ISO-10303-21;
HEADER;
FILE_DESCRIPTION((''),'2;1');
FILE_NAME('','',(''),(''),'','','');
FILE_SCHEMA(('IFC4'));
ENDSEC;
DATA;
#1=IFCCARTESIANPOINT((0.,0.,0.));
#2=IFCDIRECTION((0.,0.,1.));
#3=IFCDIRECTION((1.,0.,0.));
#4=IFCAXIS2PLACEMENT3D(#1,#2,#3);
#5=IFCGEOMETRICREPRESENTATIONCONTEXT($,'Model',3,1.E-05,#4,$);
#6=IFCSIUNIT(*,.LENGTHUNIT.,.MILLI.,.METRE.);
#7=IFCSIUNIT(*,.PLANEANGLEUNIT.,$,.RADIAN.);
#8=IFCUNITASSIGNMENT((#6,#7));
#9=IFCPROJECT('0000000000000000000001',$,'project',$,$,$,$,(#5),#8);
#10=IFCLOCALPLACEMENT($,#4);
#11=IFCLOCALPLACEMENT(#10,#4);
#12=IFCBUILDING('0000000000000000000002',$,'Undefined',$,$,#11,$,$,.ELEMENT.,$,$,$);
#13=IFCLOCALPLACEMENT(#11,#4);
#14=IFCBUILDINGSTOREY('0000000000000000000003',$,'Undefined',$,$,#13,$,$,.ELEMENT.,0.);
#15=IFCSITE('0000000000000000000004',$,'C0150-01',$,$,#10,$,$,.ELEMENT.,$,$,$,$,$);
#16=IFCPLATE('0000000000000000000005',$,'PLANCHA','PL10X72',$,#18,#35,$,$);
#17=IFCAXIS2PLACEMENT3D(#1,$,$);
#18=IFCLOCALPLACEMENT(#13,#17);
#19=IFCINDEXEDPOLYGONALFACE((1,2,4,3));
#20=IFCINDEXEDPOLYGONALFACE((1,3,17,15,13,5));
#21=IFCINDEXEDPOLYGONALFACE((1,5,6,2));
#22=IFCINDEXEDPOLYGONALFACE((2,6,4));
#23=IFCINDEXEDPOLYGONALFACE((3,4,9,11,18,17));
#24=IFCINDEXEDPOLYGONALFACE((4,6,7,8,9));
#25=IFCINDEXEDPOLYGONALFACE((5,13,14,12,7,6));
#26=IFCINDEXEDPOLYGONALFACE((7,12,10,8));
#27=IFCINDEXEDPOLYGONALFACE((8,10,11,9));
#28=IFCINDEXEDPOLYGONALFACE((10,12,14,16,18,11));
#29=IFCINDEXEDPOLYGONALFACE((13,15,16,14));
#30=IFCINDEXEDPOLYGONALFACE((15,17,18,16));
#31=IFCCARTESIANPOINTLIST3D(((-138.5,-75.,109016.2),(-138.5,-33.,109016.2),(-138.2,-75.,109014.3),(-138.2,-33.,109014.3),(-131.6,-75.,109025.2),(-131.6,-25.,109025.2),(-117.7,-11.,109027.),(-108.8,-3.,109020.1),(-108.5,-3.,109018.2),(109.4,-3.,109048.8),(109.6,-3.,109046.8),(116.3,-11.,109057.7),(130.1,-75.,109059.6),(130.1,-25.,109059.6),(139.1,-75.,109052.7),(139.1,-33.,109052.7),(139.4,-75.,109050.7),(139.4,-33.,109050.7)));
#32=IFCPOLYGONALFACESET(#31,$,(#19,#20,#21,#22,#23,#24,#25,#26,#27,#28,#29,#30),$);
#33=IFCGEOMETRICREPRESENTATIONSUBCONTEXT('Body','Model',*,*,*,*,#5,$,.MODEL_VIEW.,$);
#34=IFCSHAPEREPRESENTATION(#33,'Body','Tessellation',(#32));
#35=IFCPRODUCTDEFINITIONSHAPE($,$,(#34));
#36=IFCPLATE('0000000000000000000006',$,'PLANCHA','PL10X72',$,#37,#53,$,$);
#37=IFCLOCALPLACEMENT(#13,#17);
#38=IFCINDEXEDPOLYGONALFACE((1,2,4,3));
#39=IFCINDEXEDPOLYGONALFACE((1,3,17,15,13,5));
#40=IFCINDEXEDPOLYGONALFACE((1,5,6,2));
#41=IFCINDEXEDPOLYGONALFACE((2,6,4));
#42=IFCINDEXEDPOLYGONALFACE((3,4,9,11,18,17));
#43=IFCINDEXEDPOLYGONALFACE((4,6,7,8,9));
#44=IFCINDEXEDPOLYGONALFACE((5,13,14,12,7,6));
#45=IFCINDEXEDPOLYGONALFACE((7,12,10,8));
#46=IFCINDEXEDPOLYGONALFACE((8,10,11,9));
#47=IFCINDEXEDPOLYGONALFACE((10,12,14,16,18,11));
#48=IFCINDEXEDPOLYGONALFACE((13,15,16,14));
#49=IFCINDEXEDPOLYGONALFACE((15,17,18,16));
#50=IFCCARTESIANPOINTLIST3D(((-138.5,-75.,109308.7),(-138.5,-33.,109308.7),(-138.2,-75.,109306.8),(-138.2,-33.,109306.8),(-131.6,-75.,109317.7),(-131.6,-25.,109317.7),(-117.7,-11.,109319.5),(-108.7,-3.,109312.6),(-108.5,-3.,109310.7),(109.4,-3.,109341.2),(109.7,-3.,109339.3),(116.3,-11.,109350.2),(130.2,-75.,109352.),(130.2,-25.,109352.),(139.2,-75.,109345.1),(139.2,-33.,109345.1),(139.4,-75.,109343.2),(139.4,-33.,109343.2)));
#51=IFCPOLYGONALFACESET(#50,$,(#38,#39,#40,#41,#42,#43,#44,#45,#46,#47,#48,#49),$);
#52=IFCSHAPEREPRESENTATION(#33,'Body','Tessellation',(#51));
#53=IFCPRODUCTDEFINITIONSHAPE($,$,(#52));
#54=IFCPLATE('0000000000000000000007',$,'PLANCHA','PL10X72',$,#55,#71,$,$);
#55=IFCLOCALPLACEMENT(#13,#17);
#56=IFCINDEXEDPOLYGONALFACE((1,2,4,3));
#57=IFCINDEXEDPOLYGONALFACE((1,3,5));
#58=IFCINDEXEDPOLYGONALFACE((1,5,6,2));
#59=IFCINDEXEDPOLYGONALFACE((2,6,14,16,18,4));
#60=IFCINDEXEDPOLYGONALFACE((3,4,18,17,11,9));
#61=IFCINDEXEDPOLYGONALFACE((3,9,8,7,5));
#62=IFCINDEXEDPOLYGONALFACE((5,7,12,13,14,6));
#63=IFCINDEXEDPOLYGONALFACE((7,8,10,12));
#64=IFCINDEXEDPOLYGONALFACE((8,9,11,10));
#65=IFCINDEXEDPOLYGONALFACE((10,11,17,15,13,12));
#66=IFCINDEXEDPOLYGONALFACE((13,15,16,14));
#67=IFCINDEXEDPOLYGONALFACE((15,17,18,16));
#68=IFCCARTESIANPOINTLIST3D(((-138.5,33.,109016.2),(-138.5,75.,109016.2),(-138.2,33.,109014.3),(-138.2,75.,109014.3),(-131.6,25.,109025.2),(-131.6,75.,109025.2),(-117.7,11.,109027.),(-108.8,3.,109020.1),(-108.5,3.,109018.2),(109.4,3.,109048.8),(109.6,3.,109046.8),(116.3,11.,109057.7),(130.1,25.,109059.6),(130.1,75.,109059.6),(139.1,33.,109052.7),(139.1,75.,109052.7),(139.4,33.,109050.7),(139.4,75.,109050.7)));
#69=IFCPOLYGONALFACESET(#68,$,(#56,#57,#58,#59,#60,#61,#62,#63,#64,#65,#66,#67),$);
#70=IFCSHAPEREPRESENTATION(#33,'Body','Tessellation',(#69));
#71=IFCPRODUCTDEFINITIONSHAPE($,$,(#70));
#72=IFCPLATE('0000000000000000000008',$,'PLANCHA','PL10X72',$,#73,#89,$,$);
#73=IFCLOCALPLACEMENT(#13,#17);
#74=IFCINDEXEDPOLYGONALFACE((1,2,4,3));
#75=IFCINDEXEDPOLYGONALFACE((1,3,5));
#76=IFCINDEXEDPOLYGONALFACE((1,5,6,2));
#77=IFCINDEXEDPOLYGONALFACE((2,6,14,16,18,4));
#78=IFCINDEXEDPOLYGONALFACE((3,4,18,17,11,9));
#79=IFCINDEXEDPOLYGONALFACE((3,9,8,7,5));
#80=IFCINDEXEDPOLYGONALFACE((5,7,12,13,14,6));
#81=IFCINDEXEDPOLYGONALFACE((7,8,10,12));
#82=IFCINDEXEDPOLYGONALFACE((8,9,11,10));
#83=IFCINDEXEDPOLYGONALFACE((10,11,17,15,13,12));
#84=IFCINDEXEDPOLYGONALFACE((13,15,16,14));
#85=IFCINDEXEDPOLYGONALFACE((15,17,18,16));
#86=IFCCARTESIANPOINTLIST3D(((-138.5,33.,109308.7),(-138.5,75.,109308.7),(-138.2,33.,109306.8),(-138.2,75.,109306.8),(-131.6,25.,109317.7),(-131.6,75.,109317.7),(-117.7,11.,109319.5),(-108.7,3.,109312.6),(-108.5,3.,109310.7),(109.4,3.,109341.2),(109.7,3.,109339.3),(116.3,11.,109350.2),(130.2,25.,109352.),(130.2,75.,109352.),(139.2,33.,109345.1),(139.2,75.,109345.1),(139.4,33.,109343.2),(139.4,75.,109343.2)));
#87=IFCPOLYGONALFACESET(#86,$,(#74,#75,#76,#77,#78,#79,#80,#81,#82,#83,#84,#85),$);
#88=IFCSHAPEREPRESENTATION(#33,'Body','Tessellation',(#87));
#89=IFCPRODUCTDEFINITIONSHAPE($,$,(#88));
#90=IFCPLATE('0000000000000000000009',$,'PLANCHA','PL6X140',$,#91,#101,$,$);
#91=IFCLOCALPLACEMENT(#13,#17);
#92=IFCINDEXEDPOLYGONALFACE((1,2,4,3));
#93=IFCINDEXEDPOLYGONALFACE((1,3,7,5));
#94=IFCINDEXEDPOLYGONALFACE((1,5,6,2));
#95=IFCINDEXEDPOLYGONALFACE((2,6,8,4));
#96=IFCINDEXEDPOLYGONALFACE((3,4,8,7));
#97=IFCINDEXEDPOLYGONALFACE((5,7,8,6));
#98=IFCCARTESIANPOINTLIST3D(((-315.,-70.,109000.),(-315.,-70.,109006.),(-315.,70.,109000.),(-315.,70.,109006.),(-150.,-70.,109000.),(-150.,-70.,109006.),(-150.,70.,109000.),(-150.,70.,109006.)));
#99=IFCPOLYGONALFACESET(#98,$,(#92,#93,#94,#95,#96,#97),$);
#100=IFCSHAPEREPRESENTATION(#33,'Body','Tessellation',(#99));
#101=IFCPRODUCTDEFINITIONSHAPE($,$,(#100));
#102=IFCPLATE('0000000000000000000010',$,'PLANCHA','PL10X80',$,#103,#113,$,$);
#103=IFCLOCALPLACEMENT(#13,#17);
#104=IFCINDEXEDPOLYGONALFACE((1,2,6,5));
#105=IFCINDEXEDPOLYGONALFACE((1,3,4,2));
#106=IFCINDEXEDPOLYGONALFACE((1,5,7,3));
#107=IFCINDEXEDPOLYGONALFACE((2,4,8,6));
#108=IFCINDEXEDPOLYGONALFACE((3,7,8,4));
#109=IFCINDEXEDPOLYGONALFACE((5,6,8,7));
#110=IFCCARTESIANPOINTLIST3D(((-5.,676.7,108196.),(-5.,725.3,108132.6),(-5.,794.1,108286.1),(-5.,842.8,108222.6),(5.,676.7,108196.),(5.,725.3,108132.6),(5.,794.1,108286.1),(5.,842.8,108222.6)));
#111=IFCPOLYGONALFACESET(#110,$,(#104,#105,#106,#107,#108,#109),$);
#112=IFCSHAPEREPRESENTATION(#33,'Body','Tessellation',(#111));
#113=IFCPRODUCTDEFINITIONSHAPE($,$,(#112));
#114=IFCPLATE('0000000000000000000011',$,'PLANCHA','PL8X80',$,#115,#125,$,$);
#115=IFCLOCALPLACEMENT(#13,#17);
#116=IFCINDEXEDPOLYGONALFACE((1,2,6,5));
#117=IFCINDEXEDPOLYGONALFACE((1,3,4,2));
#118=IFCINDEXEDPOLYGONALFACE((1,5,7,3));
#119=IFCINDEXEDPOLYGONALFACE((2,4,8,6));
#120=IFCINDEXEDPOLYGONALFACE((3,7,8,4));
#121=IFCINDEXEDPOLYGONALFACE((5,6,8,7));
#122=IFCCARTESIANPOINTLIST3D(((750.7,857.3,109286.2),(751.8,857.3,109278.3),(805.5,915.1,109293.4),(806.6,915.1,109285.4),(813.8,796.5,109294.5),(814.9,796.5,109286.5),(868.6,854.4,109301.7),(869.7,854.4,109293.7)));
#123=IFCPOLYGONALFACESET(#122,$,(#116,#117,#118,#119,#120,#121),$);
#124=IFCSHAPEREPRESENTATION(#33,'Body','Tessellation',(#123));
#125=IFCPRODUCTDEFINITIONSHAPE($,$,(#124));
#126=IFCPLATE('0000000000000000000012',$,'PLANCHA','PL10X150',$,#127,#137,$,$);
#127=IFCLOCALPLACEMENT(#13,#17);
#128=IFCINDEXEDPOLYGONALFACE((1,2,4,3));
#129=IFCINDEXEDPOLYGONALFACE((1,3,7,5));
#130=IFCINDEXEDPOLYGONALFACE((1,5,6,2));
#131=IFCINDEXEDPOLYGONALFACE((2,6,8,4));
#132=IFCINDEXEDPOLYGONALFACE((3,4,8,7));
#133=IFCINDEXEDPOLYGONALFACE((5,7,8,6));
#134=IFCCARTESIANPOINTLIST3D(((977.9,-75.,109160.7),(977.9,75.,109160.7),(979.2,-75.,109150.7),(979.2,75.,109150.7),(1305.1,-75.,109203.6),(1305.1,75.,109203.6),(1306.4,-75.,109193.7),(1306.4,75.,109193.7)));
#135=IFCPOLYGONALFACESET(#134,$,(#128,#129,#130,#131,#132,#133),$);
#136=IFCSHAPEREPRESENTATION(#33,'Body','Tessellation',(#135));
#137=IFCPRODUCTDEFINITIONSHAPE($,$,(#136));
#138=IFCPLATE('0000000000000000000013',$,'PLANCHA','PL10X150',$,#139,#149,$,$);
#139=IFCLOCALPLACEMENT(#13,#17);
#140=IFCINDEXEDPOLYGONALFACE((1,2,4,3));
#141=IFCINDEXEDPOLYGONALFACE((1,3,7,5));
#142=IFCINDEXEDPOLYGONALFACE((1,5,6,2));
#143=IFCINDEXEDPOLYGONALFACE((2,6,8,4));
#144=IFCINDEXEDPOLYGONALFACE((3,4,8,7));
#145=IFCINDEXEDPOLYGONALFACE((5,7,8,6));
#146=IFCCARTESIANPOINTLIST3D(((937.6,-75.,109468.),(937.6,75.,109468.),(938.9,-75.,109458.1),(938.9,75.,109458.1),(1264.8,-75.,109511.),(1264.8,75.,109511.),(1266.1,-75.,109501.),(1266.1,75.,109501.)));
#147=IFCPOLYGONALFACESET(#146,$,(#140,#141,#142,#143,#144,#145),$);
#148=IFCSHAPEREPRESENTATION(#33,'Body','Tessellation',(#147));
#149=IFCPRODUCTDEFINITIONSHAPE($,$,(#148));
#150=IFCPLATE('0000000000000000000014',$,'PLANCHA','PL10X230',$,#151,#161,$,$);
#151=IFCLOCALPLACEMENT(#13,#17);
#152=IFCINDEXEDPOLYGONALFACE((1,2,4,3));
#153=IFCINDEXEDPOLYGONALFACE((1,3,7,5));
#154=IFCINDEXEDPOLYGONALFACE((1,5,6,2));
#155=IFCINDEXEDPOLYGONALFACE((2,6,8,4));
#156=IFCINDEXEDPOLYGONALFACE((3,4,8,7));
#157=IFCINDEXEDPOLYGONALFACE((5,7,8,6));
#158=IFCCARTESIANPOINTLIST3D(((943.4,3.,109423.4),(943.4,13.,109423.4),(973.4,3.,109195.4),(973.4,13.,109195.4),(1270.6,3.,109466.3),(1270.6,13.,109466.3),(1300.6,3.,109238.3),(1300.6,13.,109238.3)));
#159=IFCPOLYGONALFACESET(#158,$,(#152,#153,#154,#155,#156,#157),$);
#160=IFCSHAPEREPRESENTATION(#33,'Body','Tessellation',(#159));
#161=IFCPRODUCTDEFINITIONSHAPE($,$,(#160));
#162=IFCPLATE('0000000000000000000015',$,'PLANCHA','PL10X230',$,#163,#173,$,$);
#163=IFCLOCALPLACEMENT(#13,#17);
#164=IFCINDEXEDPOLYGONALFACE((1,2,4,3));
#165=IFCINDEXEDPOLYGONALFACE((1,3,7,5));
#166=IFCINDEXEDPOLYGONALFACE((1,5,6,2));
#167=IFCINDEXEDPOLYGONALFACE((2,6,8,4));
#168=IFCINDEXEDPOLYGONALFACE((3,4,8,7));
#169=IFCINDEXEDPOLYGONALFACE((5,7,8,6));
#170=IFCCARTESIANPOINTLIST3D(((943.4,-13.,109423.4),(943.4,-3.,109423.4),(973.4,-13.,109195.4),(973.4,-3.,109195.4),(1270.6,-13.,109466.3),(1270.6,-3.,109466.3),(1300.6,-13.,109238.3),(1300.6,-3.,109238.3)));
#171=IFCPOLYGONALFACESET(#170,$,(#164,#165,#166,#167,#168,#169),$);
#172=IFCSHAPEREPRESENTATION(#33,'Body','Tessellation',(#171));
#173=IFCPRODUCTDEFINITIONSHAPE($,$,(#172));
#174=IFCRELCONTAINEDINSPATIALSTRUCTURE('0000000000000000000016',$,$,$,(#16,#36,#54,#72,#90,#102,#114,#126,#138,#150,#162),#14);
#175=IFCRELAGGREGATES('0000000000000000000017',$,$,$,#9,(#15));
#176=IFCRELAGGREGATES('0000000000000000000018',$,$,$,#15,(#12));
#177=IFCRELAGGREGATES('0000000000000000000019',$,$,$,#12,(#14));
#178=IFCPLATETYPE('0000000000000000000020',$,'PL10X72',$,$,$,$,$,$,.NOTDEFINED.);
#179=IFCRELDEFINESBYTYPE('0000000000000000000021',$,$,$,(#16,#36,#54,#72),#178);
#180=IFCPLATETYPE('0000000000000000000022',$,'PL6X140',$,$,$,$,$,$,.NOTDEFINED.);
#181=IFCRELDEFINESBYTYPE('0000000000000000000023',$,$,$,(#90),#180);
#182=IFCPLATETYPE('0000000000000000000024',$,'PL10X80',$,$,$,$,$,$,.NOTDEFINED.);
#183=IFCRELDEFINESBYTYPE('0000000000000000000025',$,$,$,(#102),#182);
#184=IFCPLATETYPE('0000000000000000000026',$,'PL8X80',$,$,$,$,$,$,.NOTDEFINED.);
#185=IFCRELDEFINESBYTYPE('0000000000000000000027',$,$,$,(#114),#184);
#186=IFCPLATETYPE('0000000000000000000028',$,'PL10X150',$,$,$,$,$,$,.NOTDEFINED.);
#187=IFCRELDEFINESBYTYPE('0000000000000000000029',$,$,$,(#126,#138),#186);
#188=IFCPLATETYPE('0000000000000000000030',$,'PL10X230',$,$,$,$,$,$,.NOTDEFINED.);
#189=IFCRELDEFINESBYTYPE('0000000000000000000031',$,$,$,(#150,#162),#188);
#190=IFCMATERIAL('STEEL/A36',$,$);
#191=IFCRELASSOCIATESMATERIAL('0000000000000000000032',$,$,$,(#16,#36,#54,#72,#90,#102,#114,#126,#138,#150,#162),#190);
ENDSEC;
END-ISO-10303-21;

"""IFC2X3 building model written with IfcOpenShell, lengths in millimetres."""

from ifc_helpers import new_model, si_unit, frame, origin_with_axes, place, context, subcontext, project, spatial, polyline, outline, extrude, boolean, material, type_object, element, save


model = new_model("IFC2X3")

# Units and contexts
model_context = context("Model", 3, precision=1e-05, world=origin_with_axes())
body_context = subcontext(model_context, "Body", "Model", "MODEL_VIEW")
ifc_project = project(units=[si_unit("LENGTHUNIT", "METRE", prefix="MILLI"), si_unit("PLANEANGLEUNIT", "RADIAN")], contexts=[model_context])

# Site, building, storey
site_placement = place(None, origin_with_axes())
site = spatial("IfcSite", under=ifc_project, at=site_placement, Name="C0150-01", CompositionType="ELEMENT")
building_placement = place(site_placement, origin_with_axes())
building = spatial("IfcBuilding", under=site, at=building_placement, Name="Undefined", CompositionType="ELEMENT")
storey_placement = place(building_placement, origin_with_axes())
storey = spatial("IfcBuildingStorey", under=building, at=storey_placement, Name="Undefined", CompositionType="ELEMENT", Elevation=0.0)

# Shared definitions
ifc_material_1 = material(Name="STEEL/A36")

# Plates
plate_type_1 = type_object("IfcPlateType", Name="PL10X72", PredefinedType="NOTDEFINED")
for number, where, z_axis, x_axis, name in (
    (1, (-138.9, -75.0, 109019.2), (-0.130054, 0.0, 0.991507), (0.991507, 0.0, 0.130054), "PLANCHA"),
    (2, (-138.9, -75.0, 109311.7), (-0.130054, 0.0, 0.991507), (0.991507, 0.0, 0.130054), "PLANCHA"),
):
    element("IfcPlate", number, at=place(storey_placement, frame(where, z_axis=z_axis, x_axis=x_axis)), inside=storey, type_object=plate_type_1, material=ifc_material_1, Name=name, Description="PL10X72", context=body_context, shape_type="CSG", body=[
        boolean("DIFFERENCE", boolean("DIFFERENCE", boolean("DIFFERENCE", extrude(outline(polyline([(0.0, 0.0), (280.0, 0.0), (280.0, 42.0), (250.0, 72.0), (30.0, 72.0), (0.0, 42.0), (0.0, 0.0)])), frame((0.0, 0.0, -5.0), z_axis=(0.0, 0.0, 1.0), x_axis=(1.0, 0.0, 0.0)), (0.0, 0.0, 1.0), 10.0), extrude(outline(polyline([(0.0, 0.0), (8.0, 0.0), (8.0, 8.0), (0.0, 0.0)])), frame((-2.5, 72.0, -3.0), z_axis=(1.0, 0.0, 0.0), x_axis=(0.0, 0.0, 1.0)), (0.0, 0.0, 1.0), 285.0)), extrude(outline(polyline([(0.0, 0.0), (8.0, 0.0), (8.0, 8.0), (0.0, 0.0)])), frame((0.0, -2.5, -3.0), z_axis=(0.0, 1.0, 0.0), x_axis=(0.0, 0.0, 1.0)), (0.0, 0.0, 1.0), 77.0)), extrude(outline(polyline([(0.0, 0.0), (8.0, 0.0), (8.0, 8.0), (0.0, 0.0)])), frame((280.0, 74.5, -3.0), z_axis=(0.0, -1.0, 0.0), x_axis=(0.0, 0.0, 1.0)), (0.0, 0.0, 1.0), 77.0)),
    ])
for number, where, z_axis, x_axis, name in (
    (3, (-138.9, 75.0, 109019.2), (0.130054, 0.0, -0.991507), (0.991507, 0.0, 0.130054), "PLANCHA"),
    (4, (-138.9, 75.0, 109311.7), (0.130054, 0.0, -0.991507), (0.991507, 0.0, 0.130054), "PLANCHA"),
):
    element("IfcPlate", number, at=place(storey_placement, frame(where, z_axis=z_axis, x_axis=x_axis)), inside=storey, type_object=plate_type_1, material=ifc_material_1, Name=name, Description="PL10X72", context=body_context, shape_type="CSG", body=[
        boolean("DIFFERENCE", boolean("DIFFERENCE", boolean("DIFFERENCE", extrude(outline(polyline([(0.0, 0.0), (280.0, 0.0), (280.0, 42.0), (250.0, 72.0), (30.0, 72.0), (0.0, 42.0), (0.0, 0.0)])), frame((0.0, 0.0, -5.0), z_axis=(0.0, 0.0, 1.0), x_axis=(1.0, 0.0, 0.0)), (0.0, 0.0, 1.0), 10.0), extrude(outline(polyline([(0.0, 0.0), (8.0, 0.0), (8.0, 8.0), (0.0, 0.0)])), frame((282.5, 72.0, 3.0), z_axis=(-1.0, 0.0, 0.0), x_axis=(0.0, 0.0, -1.0)), (0.0, 0.0, 1.0), 285.0)), extrude(outline(polyline([(0.0, 0.0), (8.0, 0.0), (8.0, 8.0), (0.0, 0.0)])), frame((0.0, 74.5, 3.0), z_axis=(0.0, -1.0, 0.0), x_axis=(0.0, 0.0, -1.0)), (0.0, 0.0, 1.0), 77.0)), extrude(outline(polyline([(0.0, 0.0), (8.0, 0.0), (8.0, 8.0), (0.0, 0.0)])), frame((280.0, -2.5, 3.0), z_axis=(0.0, 1.0, 0.0), x_axis=(0.0, 0.0, -1.0)), (0.0, 0.0, 1.0), 77.0)),
    ])
plate_type_2 = type_object("IfcPlateType", Name="PL6X140", PredefinedType="NOTDEFINED")
plate_1_placement = place(storey_placement, frame((-150.0, 70.0, 109003.0), z_axis=(-0.000004, 0.0, -1.0), x_axis=(0.0, -1.0, 0.0)))
element("IfcPlate", 5, at=plate_1_placement, inside=storey, type_object=plate_type_2, material=ifc_material_1, Name="PLANCHA", Description="PL6X140", context=body_context, shape_type="SweptSolid", body=[
    extrude(outline(polyline([(0.0, 0.0), (140.0, 0.0), (140.0, 165.0), (0.0, 165.0), (0.0, 0.0)])), frame((0.0, 0.0, -3.0), z_axis=(0.0, 0.0, 1.0), x_axis=(1.0, 0.0, 0.0)), (0.0, 0.0, 1.0), 6.0),
])
plate_type_3 = type_object("IfcPlateType", Name="PL10X80", PredefinedType="NOTDEFINED")
plate_2_placement = place(storey_placement, frame((0.0, 842.8, 108222.6), z_axis=(1.0, 0.0, 0.0), x_axis=(0.0, -0.608534, 0.793528)))
element("IfcPlate", 6, at=plate_2_placement, inside=storey, type_object=plate_type_3, material=ifc_material_1, Name="PLANCHA", Description="PL10X80", context=body_context, shape_type="SweptSolid", body=[
    extrude(outline(polyline([(0.0, 0.0), (80.0, 0.0), (80.0, 148.0), (0.0, 148.0), (0.0, 0.0)])), frame((0.0, 0.0, -5.0), z_axis=(0.0, 0.0, 1.0), x_axis=(1.0, 0.0, 0.0)), (0.0, 0.0, 1.0), 10.0),
])
plate_type_4 = type_object("IfcPlateType", Name="PL8X80", PredefinedType="NOTDEFINED")
plate_3_placement = place(storey_placement, frame((806.0, 915.1, 109289.4), z_axis=(-0.130054, 0.0, 0.991507), x_axis=(-0.684698, -0.723272, -0.089811)))
element("IfcPlate", 7, at=plate_3_placement, inside=storey, type_object=plate_type_4, material=ifc_material_1, Name="PLANCHA", Description="PL8X80", context=body_context, shape_type="SweptSolid", body=[
    extrude(outline(polyline([(0.0, 0.0), (80.0, 0.0), (80.0, 88.0), (0.0, 88.0), (0.0, 0.0)])), frame((0.0, 0.0, -4.0), z_axis=(0.0, 0.0, 1.0), x_axis=(1.0, 0.0, 0.0)), (0.0, 0.0, 1.0), 8.0),
])
plate_type_5 = type_object("IfcPlateType", Name="PL10X150", PredefinedType="NOTDEFINED")
for number, where, z_axis, x_axis, name in (
    (8, (1305.8, 75.0, 109198.6), (-0.130054, 0.0, 0.991507), (-0.991507, 0.0, -0.130054), "PLANCHA"),
    (9, (1265.4, 75.0, 109506.0), (-0.130054, 0.0, 0.991507), (-0.991507, 0.0, -0.130054), "PLANCHA"),
):
    element("IfcPlate", number, at=place(storey_placement, frame(where, z_axis=z_axis, x_axis=x_axis)), inside=storey, type_object=plate_type_5, material=ifc_material_1, Name=name, Description="PL10X150", context=body_context, shape_type="SweptSolid", body=[
        extrude(outline(polyline([(0.0, 0.0), (330.0, 0.0), (330.0, 150.0), (0.0, 150.0), (0.0, 0.0)])), frame((0.0, 0.0, -5.0), z_axis=(0.0, 0.0, 1.0), x_axis=(1.0, 0.0, 0.0)), (0.0, 0.0, 1.0), 10.0),
    ])
plate_type_6 = type_object("IfcPlateType", Name="PL10X230", PredefinedType="NOTDEFINED")
for number, where, z_axis, x_axis, name in (
    (10, (943.4, 8.0, 109423.4), (0.0, -1.0, 0.0), (0.130054, 0.0, -0.991507), "PLANCHA"),
    (11, (943.4, -8.0, 109423.4), (0.0, -1.0, 0.0), (0.130054, 0.0, -0.991507), "PLANCHA"),
):
    element("IfcPlate", number, at=place(storey_placement, frame(where, z_axis=z_axis, x_axis=x_axis)), inside=storey, type_object=plate_type_6, material=ifc_material_1, Name=name, Description="PL10X230", context=body_context, shape_type="SweptSolid", body=[
        extrude(outline(polyline([(0.0, 0.0), (230.0, 0.0), (230.0, 330.0), (0.0, 330.0), (0.0, 0.0)])), frame((0.0, 0.0, -5.0), z_axis=(0.0, 0.0, 1.0), x_axis=(1.0, 0.0, 0.0)), (0.0, 0.0, 1.0), 10.0),
    ])

save(model, "model.ifc")
